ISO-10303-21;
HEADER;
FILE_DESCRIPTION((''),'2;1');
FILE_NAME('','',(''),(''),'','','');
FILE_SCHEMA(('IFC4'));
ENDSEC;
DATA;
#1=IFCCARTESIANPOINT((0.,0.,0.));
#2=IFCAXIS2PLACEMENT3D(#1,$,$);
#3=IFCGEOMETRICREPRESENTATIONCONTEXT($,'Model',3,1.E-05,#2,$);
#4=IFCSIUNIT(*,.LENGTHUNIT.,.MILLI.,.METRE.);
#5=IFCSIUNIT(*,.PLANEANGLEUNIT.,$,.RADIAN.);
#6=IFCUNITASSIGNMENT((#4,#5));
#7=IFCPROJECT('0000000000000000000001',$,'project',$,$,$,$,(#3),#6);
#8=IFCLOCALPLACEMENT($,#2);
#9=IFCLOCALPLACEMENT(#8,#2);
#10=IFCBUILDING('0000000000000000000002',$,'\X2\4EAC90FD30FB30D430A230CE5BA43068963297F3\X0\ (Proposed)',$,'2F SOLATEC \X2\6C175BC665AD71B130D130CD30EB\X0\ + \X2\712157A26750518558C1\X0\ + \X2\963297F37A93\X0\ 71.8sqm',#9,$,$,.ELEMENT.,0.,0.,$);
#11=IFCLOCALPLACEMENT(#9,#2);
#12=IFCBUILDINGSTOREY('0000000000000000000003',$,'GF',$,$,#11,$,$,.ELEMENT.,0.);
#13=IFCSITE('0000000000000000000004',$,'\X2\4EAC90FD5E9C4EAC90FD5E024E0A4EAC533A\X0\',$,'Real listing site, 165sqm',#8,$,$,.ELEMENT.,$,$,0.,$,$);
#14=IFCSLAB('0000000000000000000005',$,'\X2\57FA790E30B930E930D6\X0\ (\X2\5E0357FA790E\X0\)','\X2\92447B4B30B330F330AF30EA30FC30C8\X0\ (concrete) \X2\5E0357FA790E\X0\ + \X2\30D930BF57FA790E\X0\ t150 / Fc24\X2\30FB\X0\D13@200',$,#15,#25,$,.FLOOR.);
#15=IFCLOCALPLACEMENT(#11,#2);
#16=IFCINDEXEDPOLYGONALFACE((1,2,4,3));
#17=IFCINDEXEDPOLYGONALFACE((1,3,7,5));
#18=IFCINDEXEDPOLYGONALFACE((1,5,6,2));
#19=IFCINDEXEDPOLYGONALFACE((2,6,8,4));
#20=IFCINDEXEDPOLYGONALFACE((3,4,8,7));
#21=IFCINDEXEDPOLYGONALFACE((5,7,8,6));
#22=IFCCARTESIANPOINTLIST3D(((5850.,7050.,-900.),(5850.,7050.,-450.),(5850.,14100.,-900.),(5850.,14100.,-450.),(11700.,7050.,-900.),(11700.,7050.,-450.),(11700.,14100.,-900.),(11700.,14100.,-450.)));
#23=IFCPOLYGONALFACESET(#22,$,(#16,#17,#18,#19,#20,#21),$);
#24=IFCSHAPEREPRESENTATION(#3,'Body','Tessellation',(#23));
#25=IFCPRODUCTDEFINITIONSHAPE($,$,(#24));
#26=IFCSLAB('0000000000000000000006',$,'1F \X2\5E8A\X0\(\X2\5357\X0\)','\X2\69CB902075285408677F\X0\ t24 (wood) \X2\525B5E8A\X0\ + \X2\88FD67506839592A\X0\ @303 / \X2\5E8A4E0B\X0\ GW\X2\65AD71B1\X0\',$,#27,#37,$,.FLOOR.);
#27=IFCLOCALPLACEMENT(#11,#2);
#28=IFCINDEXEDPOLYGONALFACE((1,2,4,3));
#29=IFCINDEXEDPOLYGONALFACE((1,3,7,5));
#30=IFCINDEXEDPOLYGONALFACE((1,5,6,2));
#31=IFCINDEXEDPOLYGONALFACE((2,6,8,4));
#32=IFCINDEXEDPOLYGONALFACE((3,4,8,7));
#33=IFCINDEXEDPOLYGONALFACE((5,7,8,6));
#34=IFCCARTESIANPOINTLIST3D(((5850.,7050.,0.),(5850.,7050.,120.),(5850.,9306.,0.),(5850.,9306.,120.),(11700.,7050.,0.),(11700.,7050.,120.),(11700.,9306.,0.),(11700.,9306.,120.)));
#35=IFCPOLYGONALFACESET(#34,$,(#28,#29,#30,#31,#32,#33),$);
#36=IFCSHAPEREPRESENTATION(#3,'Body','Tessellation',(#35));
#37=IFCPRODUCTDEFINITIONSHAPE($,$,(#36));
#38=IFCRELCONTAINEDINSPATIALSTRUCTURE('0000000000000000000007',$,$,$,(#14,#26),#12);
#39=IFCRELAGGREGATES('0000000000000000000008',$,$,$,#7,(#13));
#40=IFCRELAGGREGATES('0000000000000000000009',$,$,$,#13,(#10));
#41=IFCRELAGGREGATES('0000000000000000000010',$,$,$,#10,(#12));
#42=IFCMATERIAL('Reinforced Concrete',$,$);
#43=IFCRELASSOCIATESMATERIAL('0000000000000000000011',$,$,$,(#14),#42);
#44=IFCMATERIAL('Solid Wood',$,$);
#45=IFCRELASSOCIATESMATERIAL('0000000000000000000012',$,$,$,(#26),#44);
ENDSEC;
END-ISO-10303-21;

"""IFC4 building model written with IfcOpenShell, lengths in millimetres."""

from ifc_helpers import new_model, si_unit, frame, frame_2d, origin, place, context, project, spatial, rectangle, extrude, material, element, save


model = new_model("IFC4")

# Units and contexts
model_context = context("Model", 3, precision=1e-05, world=origin())
ifc_project = project(units=[si_unit("LENGTHUNIT", "METRE", prefix="MILLI"), si_unit("PLANEANGLEUNIT", "RADIAN")], contexts=[model_context])

# Site, building, storey
site_placement = place(None, origin())
site = spatial("IfcSite", under=ifc_project, at=site_placement, Name="京都府京都市上京区", ObjectType="Real listing site, 165sqm", CompositionType="ELEMENT", RefElevation=0.0)
building_placement = place(site_placement, origin())
building = spatial("IfcBuilding", under=site, at=building_placement, Name="京都・ピアノ室と防音 (Proposed)", ObjectType="2F SOLATEC 気密断熱パネル + 無垢材内壁 + 防音窓 71.8sqm", CompositionType="ELEMENT", ElevationOfRefHeight=0.0, ElevationOfTerrain=0.0)
storey_placement = place(building_placement, origin())
storey = spatial("IfcBuildingStorey", under=building, at=storey_placement, Name="GF", CompositionType="ELEMENT", Elevation=0.0)

# Shared definitions
ifc_material_1 = material(Name="Solid Wood")

# Slabs
ifc_material_2 = material(Name="Reinforced Concrete")
slab_1_placement = place(storey_placement, frame((2925.0, 3525.0, -450.0)))
element("IfcSlab", 1, at=slab_1_placement, inside=storey, material=ifc_material_2, Name="基礎スラブ (布基礎)", Description="鉄筋コンクリート (concrete) 布基礎 + ベタ基礎 t150 / Fc24・D13@200", PredefinedType="FLOOR", context=model_context, shape_type="SweptSolid", body=[
    extrude(rectangle(XDim=5850.0, YDim=7050.0, at=frame_2d((2925.0, 3525.0))), frame((2925.0, 3525.0, -450.0)), (0.0, 0.0, 1.0), 450.0),
])
slab_2_placement = place(storey_placement, frame((2925.0, 3525.0, 0.0)))
element("IfcSlab", 2, at=slab_2_placement, inside=storey, material=ifc_material_1, Name="1F 床(南)", Description="構造用合板 t24 (wood) 剛床 + 製材根太 @303 / 床下 GW断熱", PredefinedType="FLOOR", context=model_context, shape_type="SweptSolid", body=[
    extrude(rectangle(XDim=5850.0, YDim=2256.0, at=frame_2d((2925.0, 1128.0))), frame((2925.0, 3525.0, 0.0)), (0.0, 0.0, 1.0), 120.0),
])

save(model, "model.ifc")
